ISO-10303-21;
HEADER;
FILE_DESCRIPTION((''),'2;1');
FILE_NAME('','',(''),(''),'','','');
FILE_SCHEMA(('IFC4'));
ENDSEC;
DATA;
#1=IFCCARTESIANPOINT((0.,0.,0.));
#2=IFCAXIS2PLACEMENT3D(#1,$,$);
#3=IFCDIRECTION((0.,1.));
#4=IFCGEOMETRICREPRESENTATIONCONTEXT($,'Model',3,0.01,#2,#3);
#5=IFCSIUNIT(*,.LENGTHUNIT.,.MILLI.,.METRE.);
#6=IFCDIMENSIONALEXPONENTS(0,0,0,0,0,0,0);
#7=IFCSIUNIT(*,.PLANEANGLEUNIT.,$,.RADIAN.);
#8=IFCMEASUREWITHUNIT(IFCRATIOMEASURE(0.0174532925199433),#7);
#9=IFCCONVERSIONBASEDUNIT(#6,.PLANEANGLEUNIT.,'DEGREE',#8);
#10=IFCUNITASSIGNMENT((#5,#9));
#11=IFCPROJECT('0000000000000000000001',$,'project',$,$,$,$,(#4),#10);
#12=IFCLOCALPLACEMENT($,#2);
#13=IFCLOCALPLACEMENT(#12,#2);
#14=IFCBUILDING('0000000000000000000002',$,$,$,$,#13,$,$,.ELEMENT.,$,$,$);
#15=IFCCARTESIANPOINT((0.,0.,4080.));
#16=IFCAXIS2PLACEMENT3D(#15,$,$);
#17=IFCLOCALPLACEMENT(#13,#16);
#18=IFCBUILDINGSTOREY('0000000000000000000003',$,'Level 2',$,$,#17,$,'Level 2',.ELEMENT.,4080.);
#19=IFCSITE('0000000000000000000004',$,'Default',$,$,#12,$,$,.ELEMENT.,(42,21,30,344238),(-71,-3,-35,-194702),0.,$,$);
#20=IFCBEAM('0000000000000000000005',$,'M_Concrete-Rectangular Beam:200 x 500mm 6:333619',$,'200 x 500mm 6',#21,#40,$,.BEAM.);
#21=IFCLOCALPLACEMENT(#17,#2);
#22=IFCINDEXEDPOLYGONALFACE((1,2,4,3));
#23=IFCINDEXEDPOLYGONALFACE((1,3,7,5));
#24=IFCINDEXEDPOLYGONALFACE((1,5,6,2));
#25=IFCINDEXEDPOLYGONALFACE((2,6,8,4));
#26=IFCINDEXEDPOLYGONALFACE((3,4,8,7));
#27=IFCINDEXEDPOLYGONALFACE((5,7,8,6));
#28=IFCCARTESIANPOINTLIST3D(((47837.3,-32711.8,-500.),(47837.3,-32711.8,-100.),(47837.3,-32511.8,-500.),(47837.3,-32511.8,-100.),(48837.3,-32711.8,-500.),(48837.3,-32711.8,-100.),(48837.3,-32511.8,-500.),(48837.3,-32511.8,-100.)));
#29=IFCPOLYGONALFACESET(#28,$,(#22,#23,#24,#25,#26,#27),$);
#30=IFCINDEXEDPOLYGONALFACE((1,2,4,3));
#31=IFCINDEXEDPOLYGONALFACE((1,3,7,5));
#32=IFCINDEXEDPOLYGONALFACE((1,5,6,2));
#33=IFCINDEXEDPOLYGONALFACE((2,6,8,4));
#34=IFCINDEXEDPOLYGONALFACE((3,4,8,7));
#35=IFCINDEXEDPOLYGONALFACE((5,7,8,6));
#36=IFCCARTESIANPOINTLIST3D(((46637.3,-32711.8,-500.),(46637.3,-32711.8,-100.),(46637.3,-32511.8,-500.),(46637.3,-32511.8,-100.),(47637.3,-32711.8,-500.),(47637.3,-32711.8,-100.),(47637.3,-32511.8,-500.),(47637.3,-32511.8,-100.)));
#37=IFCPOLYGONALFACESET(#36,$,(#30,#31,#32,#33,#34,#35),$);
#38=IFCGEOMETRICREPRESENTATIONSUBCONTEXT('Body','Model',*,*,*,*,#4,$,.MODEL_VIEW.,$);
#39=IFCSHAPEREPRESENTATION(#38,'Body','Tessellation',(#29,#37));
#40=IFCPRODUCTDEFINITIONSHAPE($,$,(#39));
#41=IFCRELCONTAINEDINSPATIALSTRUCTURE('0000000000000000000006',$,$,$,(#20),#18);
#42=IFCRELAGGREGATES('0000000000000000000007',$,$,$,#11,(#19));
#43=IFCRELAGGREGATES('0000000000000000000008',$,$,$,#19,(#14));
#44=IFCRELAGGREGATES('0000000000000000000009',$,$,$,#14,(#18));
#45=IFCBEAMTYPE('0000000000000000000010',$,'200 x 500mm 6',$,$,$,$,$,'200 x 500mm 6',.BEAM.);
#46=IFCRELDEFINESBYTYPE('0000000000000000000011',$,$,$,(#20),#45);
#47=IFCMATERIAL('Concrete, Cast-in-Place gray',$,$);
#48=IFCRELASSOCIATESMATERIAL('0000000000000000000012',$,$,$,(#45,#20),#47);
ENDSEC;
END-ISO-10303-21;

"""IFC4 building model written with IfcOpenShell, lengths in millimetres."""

from ifc_helpers import new_model, entity, si_unit, converted_unit, direction, frame, frame_2d, origin, place, context, subcontext, project, spatial, rectangle, extrude, source, transform, mapped, material, type_object, type_shapes, element, save


model = new_model("IFC4")

# Units and contexts
model_context = context("Model", 3, precision=0.01, world=origin(), true_north=direction((0.0, 1.0)))
body_context = subcontext(model_context, "Body", "Model", "MODEL_VIEW")
ifc_project = project(units=[si_unit("LENGTHUNIT", "METRE", prefix="MILLI"), converted_unit("PLANEANGLEUNIT", "DEGREE", entity("IfcRatioMeasure", 0.0174532925199433), si_unit("PLANEANGLEUNIT", "RADIAN"), dimensions=[0, 0, 0, 0, 0, 0, 0])], contexts=[model_context])

# Site, building, storey
site_placement = place(None, origin())
site = spatial("IfcSite", under=ifc_project, at=site_placement, Name="Default", CompositionType="ELEMENT", RefLatitude=(42, 21, 30, 344238), RefLongitude=(-71, -3, -35, -194702), RefElevation=0.0)
building_placement = place(site_placement, origin())
building = spatial("IfcBuilding", under=site, at=building_placement, CompositionType="ELEMENT")
storey_placement = place(building_placement, frame((0.0, 0.0, 4080.0)))
storey = spatial("IfcBuildingStorey", under=building, at=storey_placement, Name="Level 2", LongName="Level 2", CompositionType="ELEMENT", Elevation=4080.0)

# Beam
ifc_material_1 = material(Name="Concrete, Cast-in-Place gray")
beam_type_1 = type_object("IfcBeamType", Name="200 x 500mm 6", ElementType="200 x 500mm 6", PredefinedType="BEAM", material=ifc_material_1)
shared_shape_1 = source(origin(), body_context, "Body", "SweptSolid", [
    extrude(rectangle(XDim=1000.0, YDim=200.0, at=frame_2d((0.0, 0.0), x_axis=(1.0, 0.0))), frame((48337.3, -32611.8, 3580.0), z_axis=(0.0, 0.0, 1.0), x_axis=(-1.0, 0.0, 0.0)), (0.0, 0.0, 1.0), 400.0),
    extrude(rectangle(XDim=1000.0, YDim=200.0, at=frame_2d((0.0, 0.0), x_axis=(1.0, 0.0))), frame((47137.3, -32611.8, 3580.0)), (0.0, 0.0, 1.0), 400.0),
])
type_shapes(beam_type_1, [shared_shape_1])
beam_1_placement = place(storey_placement, frame((0.0, 0.0, -4080.0)))
element("IfcBeam", 1, at=beam_1_placement, inside=storey, type_object=beam_type_1, material=ifc_material_1, Name="M_Concrete-Rectangular Beam:200 x 500mm 6:333619", ObjectType="200 x 500mm 6", PredefinedType="BEAM", context=body_context, shape_type="MappedRepresentation", body=[
    mapped(shared_shape_1, transform((0.0, 0.0, 0.0), scale=1.0)),
])

save(model, "model.ifc")
